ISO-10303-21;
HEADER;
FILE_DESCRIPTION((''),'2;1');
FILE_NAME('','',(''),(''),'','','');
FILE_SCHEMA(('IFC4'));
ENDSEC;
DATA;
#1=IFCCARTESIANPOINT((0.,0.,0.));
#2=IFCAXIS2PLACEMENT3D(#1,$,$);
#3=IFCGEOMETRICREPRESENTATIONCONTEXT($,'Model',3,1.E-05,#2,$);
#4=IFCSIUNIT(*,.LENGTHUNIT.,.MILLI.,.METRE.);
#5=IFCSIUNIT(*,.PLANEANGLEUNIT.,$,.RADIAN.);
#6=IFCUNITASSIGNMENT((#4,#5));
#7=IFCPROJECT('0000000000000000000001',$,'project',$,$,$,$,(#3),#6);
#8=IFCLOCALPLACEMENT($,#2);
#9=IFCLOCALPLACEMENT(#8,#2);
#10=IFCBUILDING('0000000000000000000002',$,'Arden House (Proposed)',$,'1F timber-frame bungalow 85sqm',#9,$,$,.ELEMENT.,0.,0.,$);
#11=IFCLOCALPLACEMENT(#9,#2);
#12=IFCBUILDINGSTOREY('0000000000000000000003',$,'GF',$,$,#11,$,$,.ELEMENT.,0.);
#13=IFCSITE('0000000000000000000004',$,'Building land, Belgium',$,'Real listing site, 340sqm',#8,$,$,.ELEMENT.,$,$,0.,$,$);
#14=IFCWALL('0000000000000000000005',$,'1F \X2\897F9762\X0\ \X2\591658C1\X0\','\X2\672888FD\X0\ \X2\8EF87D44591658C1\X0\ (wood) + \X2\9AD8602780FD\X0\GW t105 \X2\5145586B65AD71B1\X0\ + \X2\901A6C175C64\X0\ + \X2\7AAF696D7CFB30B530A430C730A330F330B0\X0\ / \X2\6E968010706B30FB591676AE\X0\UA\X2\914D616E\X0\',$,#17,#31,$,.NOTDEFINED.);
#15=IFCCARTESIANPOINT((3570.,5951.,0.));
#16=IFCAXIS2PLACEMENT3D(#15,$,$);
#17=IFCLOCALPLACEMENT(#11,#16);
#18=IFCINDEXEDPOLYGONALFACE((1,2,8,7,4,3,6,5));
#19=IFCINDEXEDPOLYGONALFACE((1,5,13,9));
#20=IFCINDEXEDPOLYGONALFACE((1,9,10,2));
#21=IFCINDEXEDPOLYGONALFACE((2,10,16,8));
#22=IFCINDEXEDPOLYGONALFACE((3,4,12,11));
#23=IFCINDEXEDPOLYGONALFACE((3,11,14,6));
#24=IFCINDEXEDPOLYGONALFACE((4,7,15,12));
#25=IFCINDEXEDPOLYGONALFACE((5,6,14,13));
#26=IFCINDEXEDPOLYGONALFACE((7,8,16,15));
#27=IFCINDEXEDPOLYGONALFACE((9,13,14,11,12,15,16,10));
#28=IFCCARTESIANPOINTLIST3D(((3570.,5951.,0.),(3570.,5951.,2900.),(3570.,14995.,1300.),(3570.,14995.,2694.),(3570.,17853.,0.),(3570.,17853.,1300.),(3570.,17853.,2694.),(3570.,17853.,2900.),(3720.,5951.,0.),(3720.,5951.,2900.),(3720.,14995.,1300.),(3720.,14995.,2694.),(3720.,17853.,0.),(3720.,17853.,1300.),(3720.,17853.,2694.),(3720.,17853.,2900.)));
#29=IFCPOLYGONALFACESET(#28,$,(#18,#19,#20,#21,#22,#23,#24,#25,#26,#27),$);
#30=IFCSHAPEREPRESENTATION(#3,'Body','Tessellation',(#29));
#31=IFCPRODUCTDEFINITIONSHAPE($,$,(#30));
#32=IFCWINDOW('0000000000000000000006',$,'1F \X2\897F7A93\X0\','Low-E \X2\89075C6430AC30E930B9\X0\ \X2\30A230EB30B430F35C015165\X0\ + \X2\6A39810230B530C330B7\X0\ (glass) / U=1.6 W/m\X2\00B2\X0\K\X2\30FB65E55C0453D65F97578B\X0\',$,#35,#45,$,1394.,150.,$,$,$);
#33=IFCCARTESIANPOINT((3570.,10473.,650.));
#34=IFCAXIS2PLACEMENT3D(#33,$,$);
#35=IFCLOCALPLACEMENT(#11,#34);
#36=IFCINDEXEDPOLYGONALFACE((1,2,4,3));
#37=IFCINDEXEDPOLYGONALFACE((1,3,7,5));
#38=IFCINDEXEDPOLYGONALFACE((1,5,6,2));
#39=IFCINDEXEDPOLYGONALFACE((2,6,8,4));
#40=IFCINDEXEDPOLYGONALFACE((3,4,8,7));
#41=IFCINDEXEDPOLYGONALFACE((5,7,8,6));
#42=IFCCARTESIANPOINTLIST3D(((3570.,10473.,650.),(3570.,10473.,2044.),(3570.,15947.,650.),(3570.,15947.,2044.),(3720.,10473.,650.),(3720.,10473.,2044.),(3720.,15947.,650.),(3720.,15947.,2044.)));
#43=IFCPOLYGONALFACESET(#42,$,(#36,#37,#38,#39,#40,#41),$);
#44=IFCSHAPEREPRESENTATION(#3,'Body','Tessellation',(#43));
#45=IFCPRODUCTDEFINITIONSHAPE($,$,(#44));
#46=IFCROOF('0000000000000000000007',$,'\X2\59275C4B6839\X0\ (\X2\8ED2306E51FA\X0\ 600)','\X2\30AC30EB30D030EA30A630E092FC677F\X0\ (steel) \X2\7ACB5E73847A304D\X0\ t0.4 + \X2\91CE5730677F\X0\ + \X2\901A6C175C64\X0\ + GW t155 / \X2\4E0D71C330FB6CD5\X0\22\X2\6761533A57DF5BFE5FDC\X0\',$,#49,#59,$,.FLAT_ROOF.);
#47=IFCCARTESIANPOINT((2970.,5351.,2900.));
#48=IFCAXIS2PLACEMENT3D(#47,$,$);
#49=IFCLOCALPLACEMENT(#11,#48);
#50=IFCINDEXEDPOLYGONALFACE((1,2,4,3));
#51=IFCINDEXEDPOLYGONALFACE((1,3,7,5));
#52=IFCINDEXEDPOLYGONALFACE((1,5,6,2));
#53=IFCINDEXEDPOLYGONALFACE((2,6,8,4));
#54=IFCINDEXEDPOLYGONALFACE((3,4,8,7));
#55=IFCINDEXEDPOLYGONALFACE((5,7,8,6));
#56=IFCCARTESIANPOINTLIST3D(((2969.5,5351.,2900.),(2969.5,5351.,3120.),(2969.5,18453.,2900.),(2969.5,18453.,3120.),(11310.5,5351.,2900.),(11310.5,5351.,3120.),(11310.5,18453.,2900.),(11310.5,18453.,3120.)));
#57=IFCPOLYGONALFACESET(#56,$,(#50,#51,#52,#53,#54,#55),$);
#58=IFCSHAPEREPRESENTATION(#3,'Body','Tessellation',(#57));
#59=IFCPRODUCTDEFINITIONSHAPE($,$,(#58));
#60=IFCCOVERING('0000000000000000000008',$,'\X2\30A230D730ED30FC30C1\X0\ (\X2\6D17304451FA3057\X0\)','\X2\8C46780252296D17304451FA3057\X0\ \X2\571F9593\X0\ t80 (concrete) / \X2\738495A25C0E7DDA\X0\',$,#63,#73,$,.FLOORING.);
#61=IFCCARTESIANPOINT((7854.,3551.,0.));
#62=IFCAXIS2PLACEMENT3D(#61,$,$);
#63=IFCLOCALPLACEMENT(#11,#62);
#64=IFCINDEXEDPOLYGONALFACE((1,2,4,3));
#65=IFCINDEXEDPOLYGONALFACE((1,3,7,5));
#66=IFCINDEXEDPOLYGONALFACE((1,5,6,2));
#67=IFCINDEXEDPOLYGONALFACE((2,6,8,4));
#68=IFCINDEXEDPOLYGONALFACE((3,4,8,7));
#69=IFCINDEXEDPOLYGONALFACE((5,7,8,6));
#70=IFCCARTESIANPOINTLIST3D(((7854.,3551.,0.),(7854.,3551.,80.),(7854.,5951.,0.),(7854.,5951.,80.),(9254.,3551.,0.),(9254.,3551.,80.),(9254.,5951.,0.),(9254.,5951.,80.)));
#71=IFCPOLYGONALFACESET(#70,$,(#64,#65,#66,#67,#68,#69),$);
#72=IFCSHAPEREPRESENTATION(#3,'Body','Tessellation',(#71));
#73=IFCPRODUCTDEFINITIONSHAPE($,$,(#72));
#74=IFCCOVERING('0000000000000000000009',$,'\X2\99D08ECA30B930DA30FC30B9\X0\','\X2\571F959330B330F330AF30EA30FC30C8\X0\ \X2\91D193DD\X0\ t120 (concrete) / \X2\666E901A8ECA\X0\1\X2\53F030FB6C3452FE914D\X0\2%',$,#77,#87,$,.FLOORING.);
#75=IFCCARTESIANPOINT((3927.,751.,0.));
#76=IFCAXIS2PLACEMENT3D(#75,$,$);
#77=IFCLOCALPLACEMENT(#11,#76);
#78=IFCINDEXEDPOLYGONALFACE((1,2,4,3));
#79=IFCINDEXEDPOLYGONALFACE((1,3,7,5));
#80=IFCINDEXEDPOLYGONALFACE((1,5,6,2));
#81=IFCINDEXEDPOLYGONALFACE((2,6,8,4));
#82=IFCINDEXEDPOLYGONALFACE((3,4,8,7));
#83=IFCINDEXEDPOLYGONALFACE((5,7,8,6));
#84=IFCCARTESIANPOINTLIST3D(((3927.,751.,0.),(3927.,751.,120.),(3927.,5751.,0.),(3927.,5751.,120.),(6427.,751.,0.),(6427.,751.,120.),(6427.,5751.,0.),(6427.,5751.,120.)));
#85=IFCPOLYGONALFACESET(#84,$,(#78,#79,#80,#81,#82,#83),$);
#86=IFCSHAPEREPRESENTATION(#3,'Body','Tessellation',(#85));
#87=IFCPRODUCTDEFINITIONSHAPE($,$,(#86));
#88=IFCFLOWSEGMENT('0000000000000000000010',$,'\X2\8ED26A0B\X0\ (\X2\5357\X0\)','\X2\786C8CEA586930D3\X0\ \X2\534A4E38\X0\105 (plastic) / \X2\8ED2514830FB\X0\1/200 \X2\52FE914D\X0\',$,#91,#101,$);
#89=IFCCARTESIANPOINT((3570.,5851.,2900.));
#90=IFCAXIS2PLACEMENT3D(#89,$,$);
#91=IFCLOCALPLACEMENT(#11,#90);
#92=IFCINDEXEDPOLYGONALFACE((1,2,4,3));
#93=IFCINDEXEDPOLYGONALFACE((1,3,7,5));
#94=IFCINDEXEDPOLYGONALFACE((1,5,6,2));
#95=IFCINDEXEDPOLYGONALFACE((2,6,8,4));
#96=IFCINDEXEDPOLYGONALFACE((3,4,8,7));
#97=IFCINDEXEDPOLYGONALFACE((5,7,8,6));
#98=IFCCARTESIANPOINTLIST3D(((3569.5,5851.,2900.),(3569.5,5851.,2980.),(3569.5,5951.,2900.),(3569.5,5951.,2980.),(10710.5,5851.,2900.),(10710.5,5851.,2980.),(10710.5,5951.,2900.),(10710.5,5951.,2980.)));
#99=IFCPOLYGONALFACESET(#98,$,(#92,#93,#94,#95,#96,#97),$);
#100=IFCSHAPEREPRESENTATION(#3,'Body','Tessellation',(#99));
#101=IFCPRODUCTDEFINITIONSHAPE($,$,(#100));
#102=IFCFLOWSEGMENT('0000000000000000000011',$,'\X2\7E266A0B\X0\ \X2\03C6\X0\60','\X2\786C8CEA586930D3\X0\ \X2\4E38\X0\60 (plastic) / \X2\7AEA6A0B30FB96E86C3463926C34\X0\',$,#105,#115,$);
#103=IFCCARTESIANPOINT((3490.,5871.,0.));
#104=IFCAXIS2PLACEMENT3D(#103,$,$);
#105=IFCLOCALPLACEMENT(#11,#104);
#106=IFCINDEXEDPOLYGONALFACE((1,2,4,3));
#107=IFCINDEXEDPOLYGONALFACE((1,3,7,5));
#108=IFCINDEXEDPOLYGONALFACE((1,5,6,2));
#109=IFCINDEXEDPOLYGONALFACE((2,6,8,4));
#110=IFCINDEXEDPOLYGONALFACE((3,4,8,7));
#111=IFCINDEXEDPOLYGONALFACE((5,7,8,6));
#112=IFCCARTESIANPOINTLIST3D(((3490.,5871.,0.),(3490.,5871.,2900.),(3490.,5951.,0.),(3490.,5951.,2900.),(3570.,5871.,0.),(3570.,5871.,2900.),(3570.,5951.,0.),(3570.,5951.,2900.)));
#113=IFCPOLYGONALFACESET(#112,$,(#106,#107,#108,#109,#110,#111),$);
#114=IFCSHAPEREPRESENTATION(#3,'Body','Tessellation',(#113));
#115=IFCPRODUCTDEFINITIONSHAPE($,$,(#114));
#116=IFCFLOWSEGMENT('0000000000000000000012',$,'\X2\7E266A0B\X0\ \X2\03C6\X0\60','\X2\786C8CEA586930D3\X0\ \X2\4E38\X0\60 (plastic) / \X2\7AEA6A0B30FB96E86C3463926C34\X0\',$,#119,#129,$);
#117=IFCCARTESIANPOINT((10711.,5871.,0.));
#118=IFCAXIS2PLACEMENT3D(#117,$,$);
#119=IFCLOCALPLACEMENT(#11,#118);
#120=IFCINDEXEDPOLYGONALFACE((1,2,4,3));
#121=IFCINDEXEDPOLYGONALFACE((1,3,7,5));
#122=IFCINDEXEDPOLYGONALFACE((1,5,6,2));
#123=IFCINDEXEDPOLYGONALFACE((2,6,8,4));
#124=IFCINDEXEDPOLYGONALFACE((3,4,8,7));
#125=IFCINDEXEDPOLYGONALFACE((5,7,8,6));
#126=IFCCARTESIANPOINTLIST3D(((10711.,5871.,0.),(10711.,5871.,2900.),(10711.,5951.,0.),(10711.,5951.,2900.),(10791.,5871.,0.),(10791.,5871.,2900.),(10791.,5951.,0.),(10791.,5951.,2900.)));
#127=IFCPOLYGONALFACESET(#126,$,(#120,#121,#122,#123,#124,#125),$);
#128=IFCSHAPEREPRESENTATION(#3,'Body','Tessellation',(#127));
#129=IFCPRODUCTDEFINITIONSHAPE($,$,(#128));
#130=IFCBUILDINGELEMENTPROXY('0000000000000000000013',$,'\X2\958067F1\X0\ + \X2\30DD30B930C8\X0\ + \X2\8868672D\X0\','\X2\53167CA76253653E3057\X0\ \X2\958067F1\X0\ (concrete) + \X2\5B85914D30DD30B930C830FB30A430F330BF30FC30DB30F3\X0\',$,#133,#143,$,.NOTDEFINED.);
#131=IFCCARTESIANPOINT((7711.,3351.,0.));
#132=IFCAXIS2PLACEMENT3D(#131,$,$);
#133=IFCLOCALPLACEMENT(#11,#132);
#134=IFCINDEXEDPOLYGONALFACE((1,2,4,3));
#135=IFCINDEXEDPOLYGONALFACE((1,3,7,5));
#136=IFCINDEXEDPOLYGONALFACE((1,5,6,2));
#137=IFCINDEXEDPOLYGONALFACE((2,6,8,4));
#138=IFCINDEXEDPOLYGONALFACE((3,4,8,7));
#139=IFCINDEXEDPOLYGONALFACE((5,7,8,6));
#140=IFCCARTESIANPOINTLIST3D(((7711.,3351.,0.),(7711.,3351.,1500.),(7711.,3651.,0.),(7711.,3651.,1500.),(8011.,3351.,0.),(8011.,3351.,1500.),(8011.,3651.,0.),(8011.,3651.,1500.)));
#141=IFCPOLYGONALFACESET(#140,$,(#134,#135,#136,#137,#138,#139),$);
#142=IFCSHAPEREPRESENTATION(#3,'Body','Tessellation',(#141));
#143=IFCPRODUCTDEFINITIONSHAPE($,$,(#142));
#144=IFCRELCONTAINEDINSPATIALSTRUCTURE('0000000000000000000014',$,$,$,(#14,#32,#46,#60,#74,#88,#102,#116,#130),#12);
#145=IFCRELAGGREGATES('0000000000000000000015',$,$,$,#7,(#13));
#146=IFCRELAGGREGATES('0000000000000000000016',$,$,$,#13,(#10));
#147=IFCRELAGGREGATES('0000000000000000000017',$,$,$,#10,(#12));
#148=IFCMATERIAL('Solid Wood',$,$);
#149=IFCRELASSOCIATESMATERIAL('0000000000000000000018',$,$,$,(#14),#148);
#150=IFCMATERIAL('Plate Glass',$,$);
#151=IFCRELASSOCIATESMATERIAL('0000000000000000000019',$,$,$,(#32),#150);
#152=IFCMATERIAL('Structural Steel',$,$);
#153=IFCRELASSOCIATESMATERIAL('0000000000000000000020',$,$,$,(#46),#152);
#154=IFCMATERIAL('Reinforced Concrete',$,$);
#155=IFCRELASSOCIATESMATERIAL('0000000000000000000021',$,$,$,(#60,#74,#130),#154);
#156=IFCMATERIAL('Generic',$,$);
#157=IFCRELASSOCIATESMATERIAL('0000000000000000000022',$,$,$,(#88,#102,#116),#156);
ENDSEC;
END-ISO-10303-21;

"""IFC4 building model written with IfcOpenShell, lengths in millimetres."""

from ifc_helpers import new_model, si_unit, frame, frame_2d, origin, place, context, project, spatial, rectangle, extrude, material, element, fill, save


model = new_model("IFC4")

# Units and contexts
model_context = context("Model", 3, precision=1e-05, world=origin())
ifc_project = project(units=[si_unit("LENGTHUNIT", "METRE", prefix="MILLI"), si_unit("PLANEANGLEUNIT", "RADIAN")], contexts=[model_context])

# Site, building, storey
site_placement = place(None, origin())
site = spatial("IfcSite", under=ifc_project, at=site_placement, Name="Building land, Belgium", ObjectType="Real listing site, 340sqm", CompositionType="ELEMENT", RefElevation=0.0)
building_placement = place(site_placement, origin())
building = spatial("IfcBuilding", under=site, at=building_placement, Name="Arden House (Proposed)", ObjectType="1F timber-frame bungalow 85sqm", CompositionType="ELEMENT", ElevationOfRefHeight=0.0, ElevationOfTerrain=0.0)
storey_placement = place(building_placement, origin())
storey = spatial("IfcBuildingStorey", under=building, at=storey_placement, Name="GF", CompositionType="ELEMENT", Elevation=0.0)

# Shared definitions
ifc_material_1 = material(Name="Solid Wood")

# Shared definitions
ifc_material_2 = material(Name="Reinforced Concrete")

# Shared definitions
ifc_material_3 = material(Name="Plate Glass")

# Wall, opening, window
wall_1_placement = place(storey_placement, frame((3570.0, 5951.0, 0.0)))
wall_1 = element("IfcWall", 1, at=wall_1_placement, inside=storey, material=ifc_material_1, Name="1F 西面 外壁", Description="木製 軸組外壁 (wood) + 高性能GW t105 充填断熱 + 通気層 + 窯業系サイディング / 準耐火・外皮UA配慮", PredefinedType="NOTDEFINED", context=model_context, shape_type="SweptSolid", body=[
    extrude(rectangle(XDim=150.0, YDim=11902.0, at=frame_2d((75.0, 5951.0))), frame((3570.0, 5951.0, 0.0)), (0.0, 0.0, 1.0), 2900.0),
])
opening_1_placement = place(storey_placement, frame((3570.0, 10473.0, 650.0)))
opening_1 = element("IfcOpeningElement", 2, at=opening_1_placement, cuts=wall_1, PredefinedType="NOTDEFINED", context=model_context, shape_type="SweptSolid", body=[
    extrude(rectangle(XDim=150.0, YDim=5474.0, at=frame_2d((75.0, 2737.0))), frame((3570.0, 10473.0, 650.0)), (0.0, 0.0, 1.0), 1394.0),
])
window_1_placement = place(storey_placement, frame((3570.0, 10473.0, 650.0)))
window_1 = element("IfcWindow", 3, at=window_1_placement, inside=storey, material=ifc_material_3, Name="1F 西窓", Description="Low-E 複層ガラス アルゴン封入 + 樹脂サッシ (glass) / U=1.6 W/m²K・日射取得型", OverallHeight=1394.0, OverallWidth=150.0, context=model_context, shape_type="SweptSolid", body=[
    extrude(rectangle(XDim=150.0, YDim=5474.0, at=frame_2d((75.0, 2737.0))), frame((3570.0, 10473.0, 650.0)), (0.0, 0.0, 1.0), 1394.0),
])
fill(opening_1, window_1)

# Roof
ifc_material_4 = material(Name="Structural Steel")
roof_placement = place(storey_placement, frame((2970.0, 5351.0, 2900.0)))
element("IfcRoof", 4, at=roof_placement, inside=storey, material=ifc_material_4, Name="大屋根 (軒の出 600)", Description="ガルバリウム鋼板 (steel) 立平葺き t0.4 + 野地板 + 通気層 + GW t155 / 不燃・法22条区域対応", PredefinedType="FLAT_ROOF", context=model_context, shape_type="SweptSolid", body=[
    extrude(rectangle(XDim=8341.0, YDim=13102.0, at=frame_2d((4170.0, 6551.0))), frame((2970.0, 5351.0, 2900.0)), (0.0, 0.0, 1.0), 220.0),
])

# Coverings
covering_1_placement = place(storey_placement, frame((7854.0, 3551.0, 0.0)))
element("IfcCovering", 5, at=covering_1_placement, inside=storey, material=ifc_material_2, Name="アプローチ (洗い出し)", Description="豆砂利洗い出し 土間 t80 (concrete) / 玄関導線", PredefinedType="FLOORING", context=model_context, shape_type="SweptSolid", body=[
    extrude(rectangle(XDim=1400.0, YDim=2400.0, at=frame_2d((700.0, 1200.0))), frame((7854.0, 3551.0, 0.0)), (0.0, 0.0, 1.0), 80.0),
])
covering_2_placement = place(storey_placement, frame((3927.0, 751.0, 0.0)))
element("IfcCovering", 6, at=covering_2_placement, inside=storey, material=ifc_material_2, Name="駐車スペース", Description="土間コンクリート 金鏝 t120 (concrete) / 普通車1台・水勾配2%", PredefinedType="FLOORING", context=model_context, shape_type="SweptSolid", body=[
    extrude(rectangle(XDim=2500.0, YDim=5000.0, at=frame_2d((1250.0, 2500.0))), frame((3927.0, 751.0, 0.0)), (0.0, 0.0, 1.0), 120.0),
])

# Flow segments
ifc_material_5 = material(Name="Generic")
flow_segment_1_placement = place(storey_placement, frame((3570.0, 5851.0, 2900.0)))
element("IfcFlowSegment", 7, at=flow_segment_1_placement, inside=storey, material=ifc_material_5, Name="軒樋 (南)", Description="硬質塩ビ 半丸105 (plastic) / 軒先・1/200 勾配", context=model_context, shape_type="SweptSolid", body=[
    extrude(rectangle(XDim=7141.0, YDim=100.0, at=frame_2d((3570.0, 50.0))), frame((3570.0, 5851.0, 2900.0)), (0.0, 0.0, 1.0), 80.0),
])
flow_segment_2_placement = place(storey_placement, frame((3490.0, 5871.0, 0.0)))
element("IfcFlowSegment", 8, at=flow_segment_2_placement, inside=storey, material=ifc_material_5, Name="縦樋 φ60", Description="硬質塩ビ 丸60 (plastic) / 竪樋・雨水排水", context=model_context, shape_type="SweptSolid", body=[
    extrude(rectangle(XDim=80.0, YDim=80.0, at=frame_2d((40.0, 40.0))), frame((3490.0, 5871.0, 0.0)), (0.0, 0.0, 1.0), 2900.0),
])
flow_segment_3_placement = place(storey_placement, frame((10711.0, 5871.0, 0.0)))
element("IfcFlowSegment", 9, at=flow_segment_3_placement, inside=storey, material=ifc_material_5, Name="縦樋 φ60", Description="硬質塩ビ 丸60 (plastic) / 竪樋・雨水排水", context=model_context, shape_type="SweptSolid", body=[
    extrude(rectangle(XDim=80.0, YDim=80.0, at=frame_2d((40.0, 40.0))), frame((10711.0, 5871.0, 0.0)), (0.0, 0.0, 1.0), 2900.0),
])

# Building element proxy
proxy_placement = place(storey_placement, frame((7711.0, 3351.0, 0.0)))
element("IfcBuildingElementProxy", 10, at=proxy_placement, inside=storey, material=ifc_material_2, Name="門柱 + ポスト + 表札", Description="化粧打放し 門柱 (concrete) + 宅配ポスト・インターホン", PredefinedType="NOTDEFINED", context=model_context, shape_type="SweptSolid", body=[
    extrude(rectangle(XDim=300.0, YDim=300.0, at=frame_2d((150.0, 150.0))), frame((7711.0, 3351.0, 0.0)), (0.0, 0.0, 1.0), 1500.0),
])

save(model, "model.ifc")
